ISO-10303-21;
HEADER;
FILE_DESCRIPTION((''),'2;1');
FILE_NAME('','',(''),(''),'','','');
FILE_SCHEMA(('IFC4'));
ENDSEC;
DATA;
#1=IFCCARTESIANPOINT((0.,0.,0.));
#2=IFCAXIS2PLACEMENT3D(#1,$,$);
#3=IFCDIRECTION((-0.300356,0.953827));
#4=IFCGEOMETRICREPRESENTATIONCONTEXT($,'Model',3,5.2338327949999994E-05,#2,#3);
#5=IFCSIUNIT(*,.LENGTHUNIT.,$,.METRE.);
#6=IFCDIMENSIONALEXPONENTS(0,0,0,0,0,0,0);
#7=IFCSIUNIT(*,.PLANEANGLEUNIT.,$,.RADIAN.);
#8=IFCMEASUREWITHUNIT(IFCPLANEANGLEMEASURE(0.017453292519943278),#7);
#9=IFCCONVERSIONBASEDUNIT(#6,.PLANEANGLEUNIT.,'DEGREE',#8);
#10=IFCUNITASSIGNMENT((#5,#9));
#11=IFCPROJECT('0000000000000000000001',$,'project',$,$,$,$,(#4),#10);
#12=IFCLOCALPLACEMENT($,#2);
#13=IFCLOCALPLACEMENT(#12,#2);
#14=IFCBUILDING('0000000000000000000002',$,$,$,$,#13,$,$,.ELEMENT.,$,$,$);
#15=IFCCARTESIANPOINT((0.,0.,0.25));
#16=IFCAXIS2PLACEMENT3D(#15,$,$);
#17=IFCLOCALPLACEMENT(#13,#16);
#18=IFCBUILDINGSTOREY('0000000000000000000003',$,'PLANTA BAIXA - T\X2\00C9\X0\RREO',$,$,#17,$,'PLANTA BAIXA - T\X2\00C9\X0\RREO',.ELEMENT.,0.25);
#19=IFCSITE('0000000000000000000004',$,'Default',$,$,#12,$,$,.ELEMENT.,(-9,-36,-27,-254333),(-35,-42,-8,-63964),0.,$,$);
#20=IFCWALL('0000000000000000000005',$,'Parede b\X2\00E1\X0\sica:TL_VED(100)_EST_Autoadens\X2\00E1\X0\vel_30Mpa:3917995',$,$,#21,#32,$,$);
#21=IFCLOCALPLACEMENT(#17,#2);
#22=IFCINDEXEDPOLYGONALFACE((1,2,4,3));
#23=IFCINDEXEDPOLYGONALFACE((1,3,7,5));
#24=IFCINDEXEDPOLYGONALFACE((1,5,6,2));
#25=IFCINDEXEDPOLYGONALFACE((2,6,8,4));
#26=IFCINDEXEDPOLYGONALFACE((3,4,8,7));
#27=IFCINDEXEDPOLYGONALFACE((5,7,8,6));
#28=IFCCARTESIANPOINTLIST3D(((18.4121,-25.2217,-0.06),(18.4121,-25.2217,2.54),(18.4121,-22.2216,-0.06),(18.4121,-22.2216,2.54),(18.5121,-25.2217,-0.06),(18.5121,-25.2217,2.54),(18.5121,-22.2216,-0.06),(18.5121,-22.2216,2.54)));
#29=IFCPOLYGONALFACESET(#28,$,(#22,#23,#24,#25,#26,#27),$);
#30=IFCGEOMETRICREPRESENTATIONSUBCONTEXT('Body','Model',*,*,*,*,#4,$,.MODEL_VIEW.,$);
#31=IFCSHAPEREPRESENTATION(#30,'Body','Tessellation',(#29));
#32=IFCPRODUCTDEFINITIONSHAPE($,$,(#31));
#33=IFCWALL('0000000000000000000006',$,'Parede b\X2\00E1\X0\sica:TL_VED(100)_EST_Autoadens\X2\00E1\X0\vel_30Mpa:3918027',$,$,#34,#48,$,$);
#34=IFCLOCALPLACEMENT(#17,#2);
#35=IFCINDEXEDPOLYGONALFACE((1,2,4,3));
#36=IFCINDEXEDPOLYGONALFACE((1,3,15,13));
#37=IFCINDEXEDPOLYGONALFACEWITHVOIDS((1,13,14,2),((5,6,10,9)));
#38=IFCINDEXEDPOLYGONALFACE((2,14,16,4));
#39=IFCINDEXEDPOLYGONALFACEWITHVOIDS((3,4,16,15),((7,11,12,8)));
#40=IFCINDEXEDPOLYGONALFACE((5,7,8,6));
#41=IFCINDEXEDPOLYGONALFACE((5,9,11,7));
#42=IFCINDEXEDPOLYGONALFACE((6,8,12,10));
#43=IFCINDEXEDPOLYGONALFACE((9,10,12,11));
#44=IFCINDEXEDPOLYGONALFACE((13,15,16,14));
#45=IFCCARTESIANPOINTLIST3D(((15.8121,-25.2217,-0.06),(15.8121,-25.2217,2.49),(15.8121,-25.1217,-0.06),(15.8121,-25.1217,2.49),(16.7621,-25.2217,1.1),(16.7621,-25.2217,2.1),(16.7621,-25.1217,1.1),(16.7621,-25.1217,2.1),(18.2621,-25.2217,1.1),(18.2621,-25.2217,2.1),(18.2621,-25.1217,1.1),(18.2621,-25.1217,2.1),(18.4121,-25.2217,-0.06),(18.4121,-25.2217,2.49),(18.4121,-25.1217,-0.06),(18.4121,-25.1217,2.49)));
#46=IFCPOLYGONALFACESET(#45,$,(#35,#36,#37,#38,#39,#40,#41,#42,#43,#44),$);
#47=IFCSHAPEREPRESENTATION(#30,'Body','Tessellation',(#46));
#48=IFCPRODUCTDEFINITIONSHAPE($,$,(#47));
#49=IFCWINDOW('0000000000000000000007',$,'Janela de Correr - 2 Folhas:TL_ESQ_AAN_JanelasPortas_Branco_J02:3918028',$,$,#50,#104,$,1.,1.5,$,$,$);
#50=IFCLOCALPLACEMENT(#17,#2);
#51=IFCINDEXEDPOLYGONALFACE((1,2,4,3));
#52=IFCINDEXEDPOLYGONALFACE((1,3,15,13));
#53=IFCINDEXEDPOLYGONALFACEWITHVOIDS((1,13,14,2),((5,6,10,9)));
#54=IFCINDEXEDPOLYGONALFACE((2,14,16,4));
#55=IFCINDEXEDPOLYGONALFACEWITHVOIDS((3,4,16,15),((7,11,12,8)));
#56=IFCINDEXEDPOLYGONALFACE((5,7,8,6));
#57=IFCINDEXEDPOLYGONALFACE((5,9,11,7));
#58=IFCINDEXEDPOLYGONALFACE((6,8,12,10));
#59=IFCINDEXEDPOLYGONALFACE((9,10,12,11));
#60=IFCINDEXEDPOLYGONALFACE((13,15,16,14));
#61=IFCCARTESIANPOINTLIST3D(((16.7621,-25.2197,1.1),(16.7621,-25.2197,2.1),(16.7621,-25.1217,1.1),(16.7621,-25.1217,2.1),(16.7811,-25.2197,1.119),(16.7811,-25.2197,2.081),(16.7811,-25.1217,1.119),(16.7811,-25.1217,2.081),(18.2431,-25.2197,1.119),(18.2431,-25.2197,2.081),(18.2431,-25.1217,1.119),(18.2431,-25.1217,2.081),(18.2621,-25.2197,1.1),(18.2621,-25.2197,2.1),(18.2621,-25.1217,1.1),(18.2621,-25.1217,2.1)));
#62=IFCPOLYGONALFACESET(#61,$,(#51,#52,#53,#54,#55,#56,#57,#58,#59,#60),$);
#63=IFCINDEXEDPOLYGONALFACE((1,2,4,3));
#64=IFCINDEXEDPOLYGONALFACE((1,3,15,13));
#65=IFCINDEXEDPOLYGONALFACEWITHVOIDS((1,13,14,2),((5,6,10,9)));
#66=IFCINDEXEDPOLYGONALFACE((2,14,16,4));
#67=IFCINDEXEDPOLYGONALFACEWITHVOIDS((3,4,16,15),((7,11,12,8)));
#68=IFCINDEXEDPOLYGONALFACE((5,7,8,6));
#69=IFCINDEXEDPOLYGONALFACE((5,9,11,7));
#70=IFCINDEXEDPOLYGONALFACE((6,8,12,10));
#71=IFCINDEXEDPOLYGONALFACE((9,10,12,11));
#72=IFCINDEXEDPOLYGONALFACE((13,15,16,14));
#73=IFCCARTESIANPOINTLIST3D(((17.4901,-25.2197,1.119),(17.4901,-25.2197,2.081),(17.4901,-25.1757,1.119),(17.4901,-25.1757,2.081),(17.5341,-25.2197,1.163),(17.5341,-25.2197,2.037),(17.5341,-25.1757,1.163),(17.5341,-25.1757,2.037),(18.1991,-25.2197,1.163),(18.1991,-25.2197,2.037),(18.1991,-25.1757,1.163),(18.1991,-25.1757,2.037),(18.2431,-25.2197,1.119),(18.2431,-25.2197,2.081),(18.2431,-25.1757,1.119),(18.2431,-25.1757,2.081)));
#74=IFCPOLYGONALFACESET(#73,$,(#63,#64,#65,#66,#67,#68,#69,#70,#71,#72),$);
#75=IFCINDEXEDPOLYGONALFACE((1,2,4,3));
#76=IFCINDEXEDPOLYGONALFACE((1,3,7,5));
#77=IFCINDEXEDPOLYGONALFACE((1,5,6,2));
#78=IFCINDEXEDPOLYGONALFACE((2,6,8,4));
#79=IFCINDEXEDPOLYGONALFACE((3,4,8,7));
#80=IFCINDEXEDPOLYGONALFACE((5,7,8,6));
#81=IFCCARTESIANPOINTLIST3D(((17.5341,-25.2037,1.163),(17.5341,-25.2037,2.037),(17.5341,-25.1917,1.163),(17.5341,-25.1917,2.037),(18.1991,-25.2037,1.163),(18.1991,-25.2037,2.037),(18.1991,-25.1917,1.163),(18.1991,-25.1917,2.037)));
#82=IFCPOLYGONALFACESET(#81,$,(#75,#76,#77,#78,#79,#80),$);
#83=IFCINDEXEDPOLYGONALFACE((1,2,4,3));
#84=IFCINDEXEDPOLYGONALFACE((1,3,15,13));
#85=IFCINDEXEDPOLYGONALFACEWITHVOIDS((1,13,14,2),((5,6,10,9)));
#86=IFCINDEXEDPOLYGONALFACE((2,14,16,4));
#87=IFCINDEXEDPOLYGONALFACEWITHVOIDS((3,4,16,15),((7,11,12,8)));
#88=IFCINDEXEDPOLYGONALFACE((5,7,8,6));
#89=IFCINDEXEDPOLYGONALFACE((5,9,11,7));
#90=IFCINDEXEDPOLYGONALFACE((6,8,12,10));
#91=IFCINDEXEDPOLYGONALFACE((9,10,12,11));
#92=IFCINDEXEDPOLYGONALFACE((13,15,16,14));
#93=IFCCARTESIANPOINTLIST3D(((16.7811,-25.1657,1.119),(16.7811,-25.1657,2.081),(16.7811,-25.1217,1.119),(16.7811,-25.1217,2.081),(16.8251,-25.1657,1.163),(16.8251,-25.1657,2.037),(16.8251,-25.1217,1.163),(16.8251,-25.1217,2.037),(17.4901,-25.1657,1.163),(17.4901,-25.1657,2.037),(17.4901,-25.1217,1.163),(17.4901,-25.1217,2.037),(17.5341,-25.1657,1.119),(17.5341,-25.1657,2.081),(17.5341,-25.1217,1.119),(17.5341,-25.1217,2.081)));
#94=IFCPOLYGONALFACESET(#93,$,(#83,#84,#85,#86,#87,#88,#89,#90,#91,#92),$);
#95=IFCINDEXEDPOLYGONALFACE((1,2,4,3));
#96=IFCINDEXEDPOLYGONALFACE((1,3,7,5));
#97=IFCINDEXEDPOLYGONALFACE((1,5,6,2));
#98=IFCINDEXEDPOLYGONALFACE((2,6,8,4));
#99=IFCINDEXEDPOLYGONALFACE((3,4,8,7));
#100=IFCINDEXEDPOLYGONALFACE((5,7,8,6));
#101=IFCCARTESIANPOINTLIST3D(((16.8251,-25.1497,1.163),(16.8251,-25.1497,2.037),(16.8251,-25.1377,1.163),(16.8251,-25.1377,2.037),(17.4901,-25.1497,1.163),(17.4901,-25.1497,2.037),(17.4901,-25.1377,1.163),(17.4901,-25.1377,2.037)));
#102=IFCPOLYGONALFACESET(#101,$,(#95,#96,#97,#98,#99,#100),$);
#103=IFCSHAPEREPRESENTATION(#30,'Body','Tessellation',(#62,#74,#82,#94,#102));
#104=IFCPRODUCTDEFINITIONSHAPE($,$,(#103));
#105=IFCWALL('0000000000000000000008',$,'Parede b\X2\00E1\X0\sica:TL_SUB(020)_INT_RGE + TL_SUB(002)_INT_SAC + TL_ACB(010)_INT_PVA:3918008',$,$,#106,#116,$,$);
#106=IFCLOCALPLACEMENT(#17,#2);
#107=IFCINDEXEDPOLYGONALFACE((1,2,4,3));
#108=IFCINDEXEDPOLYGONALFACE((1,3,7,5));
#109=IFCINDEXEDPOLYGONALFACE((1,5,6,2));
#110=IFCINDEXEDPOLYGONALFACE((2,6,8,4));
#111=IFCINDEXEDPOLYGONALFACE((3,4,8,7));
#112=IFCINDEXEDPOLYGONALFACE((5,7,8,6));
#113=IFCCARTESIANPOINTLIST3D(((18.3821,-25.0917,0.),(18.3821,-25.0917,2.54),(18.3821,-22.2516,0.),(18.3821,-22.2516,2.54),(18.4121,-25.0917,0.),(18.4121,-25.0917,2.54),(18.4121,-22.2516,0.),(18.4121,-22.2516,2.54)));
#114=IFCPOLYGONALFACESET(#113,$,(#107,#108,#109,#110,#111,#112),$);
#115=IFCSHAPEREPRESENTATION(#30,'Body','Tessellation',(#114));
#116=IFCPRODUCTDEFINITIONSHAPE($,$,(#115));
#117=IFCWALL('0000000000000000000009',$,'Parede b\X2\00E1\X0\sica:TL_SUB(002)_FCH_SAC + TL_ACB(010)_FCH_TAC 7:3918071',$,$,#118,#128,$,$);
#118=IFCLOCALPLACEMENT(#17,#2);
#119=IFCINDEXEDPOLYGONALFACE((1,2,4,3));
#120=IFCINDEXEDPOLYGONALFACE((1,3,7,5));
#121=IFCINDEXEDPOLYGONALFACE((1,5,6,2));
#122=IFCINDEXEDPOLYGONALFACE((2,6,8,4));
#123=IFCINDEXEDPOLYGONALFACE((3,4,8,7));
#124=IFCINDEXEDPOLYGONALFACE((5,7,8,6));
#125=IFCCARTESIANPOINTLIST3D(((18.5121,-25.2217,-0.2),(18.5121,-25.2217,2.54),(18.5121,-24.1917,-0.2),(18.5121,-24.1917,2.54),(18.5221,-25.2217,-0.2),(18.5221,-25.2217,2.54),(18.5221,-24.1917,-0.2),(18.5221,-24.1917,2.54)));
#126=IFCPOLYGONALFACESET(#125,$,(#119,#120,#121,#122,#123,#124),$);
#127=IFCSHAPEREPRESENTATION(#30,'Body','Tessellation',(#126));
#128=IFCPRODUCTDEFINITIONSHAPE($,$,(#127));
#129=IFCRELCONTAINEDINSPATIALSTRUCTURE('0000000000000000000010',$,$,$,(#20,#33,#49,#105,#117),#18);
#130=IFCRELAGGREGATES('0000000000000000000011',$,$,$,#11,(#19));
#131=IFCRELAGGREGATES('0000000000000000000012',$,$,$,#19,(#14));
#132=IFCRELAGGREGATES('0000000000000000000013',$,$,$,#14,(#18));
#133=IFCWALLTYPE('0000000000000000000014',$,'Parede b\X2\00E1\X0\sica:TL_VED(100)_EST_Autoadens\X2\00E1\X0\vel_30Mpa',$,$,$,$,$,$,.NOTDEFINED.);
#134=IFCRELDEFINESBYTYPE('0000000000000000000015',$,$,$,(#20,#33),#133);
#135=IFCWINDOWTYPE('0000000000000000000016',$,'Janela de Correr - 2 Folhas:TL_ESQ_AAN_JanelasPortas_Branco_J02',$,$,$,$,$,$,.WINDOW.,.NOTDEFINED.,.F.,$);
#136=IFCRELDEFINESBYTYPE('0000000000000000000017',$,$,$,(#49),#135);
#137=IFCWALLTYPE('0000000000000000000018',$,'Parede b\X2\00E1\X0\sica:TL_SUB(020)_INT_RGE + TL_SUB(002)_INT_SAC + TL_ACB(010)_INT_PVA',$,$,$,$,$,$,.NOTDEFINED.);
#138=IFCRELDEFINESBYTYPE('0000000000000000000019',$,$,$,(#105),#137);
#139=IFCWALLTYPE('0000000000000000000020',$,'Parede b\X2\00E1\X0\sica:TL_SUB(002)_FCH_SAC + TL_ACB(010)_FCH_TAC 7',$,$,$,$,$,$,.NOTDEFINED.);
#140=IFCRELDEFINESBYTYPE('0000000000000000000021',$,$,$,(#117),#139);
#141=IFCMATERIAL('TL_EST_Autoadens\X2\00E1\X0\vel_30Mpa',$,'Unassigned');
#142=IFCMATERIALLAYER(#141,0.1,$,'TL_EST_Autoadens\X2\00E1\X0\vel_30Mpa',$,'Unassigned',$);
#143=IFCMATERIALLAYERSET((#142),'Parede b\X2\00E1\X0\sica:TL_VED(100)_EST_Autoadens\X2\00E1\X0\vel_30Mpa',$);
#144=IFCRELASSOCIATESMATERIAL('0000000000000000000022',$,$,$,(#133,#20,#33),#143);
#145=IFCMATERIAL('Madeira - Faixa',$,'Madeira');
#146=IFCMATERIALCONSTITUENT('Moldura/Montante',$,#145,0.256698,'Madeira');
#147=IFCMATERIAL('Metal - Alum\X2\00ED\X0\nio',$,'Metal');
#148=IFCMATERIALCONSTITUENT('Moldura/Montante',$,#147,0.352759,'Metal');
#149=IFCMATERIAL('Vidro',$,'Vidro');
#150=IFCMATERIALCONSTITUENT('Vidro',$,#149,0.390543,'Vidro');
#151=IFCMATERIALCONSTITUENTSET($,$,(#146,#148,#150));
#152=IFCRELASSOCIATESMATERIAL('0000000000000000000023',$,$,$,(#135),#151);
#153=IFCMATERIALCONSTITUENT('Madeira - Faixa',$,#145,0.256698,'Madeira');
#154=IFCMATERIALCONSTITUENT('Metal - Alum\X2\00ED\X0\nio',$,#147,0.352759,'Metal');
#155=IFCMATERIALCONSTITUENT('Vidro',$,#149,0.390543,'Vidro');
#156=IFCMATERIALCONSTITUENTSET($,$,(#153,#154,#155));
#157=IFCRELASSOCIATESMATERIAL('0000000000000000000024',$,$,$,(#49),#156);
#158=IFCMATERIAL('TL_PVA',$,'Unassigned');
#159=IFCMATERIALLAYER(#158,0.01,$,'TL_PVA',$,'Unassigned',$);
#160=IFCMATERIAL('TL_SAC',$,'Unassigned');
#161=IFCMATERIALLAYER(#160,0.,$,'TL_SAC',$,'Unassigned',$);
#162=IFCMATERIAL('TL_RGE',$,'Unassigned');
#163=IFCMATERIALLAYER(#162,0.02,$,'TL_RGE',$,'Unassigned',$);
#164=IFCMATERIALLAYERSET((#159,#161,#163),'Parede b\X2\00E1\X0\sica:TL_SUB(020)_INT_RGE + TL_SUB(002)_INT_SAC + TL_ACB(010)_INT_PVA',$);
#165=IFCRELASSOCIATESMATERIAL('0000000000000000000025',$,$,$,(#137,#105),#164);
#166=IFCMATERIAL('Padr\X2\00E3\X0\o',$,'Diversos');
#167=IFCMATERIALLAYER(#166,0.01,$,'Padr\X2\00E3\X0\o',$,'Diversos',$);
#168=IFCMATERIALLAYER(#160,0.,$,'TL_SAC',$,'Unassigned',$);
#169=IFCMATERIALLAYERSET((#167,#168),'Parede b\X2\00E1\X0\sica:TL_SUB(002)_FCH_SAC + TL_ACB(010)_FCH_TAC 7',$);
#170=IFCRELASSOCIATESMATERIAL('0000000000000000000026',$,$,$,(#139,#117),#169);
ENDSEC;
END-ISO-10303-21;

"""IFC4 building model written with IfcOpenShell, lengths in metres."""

from ifc_helpers import new_model, entity, si_unit, converted_unit, direction, frame, frame_2d, origin, origin_2d_with_axis, place, context, subcontext, project, spatial, polyline, rectangle, outline, extrude, source, transform, mapped, material, layer, layer_set, layer_usage, constituent, constituent_set, type_object, type_shapes, element, fill, save


model = new_model("IFC4")

# Units and contexts
model_context = context("Model", 3, precision=5.2338327949999994e-05, world=origin(), true_north=direction((-0.300356, 0.953827)))
body_context = subcontext(model_context, "Body", "Model", "MODEL_VIEW")
ifc_project = project(units=[si_unit("LENGTHUNIT", "METRE"), converted_unit("PLANEANGLEUNIT", "DEGREE", entity("IfcPlaneAngleMeasure", 0.017453292519943278), si_unit("PLANEANGLEUNIT", "RADIAN"), dimensions=[0, 0, 0, 0, 0, 0, 0])], contexts=[model_context])

# Site, building, storey
site_placement = place(None, origin())
site = spatial("IfcSite", under=ifc_project, at=site_placement, Name="Default", CompositionType="ELEMENT", RefLatitude=(-9, -36, -27, -254333), RefLongitude=(-35, -42, -8, -63964), RefElevation=0.0)
building_placement = place(site_placement, origin())
building = spatial("IfcBuilding", under=site, at=building_placement, CompositionType="ELEMENT")
storey_placement = place(building_placement, frame((0.0, 0.0, 0.25)))
storey = spatial("IfcBuildingStorey", under=building, at=storey_placement, Name="PLANTA BAIXA - TÉRREO", LongName="PLANTA BAIXA - TÉRREO", CompositionType="ELEMENT", Elevation=0.25)

# Wall
ifc_material_1 = material(Name="TL_EST_Autoadensável_30Mpa", Category="Unassigned")
ifc_layer_1 = layer(ifc_material_1, 0.1, Name="TL_EST_Autoadensável_30Mpa", Category="Unassigned")
ifc_layer_set_1 = layer_set([ifc_layer_1], Name="Parede básica:TL_VED(100)_EST_Autoadensável_30Mpa")
ifc_layer_usage_1 = layer_usage(ifc_layer_set_1, "AXIS2", "NEGATIVE", 0.05)
wall_type_1 = type_object("IfcWallType", Name="Parede básica:TL_VED(100)_EST_Autoadensável_30Mpa", PredefinedType="NOTDEFINED", material=ifc_layer_set_1)
wall_1_placement = place(storey_placement, frame((18.4621, -25.2217, -0.06), z_axis=(0.0, 0.0, 1.0), x_axis=(0.0, 1.0, 0.0)))
element("IfcWall", 1, at=wall_1_placement, inside=storey, type_object=wall_type_1, material=ifc_layer_usage_1, Name="Parede básica:TL_VED(100)_EST_Autoadensável_30Mpa:3917995", context=body_context, shape_type="SweptSolid", body=[
    extrude(rectangle(XDim=3.0001, YDim=0.1, at=frame_2d((1.5001, 0.0), x_axis=(-1.0, 0.0))), origin(), (0.0, 0.0, 1.0), 2.6),
])

# Wall, opening, window
ifc_layer_usage_2 = layer_usage(ifc_layer_set_1, "AXIS2", "NEGATIVE", 0.05)
wall_2_placement = place(storey_placement, frame((18.4121, -25.1717, -0.06), z_axis=(0.0, 0.0, 1.0), x_axis=(-1.0, 0.0, 0.0)))
wall_2 = element("IfcWall", 2, at=wall_2_placement, inside=storey, type_object=wall_type_1, material=ifc_layer_usage_2, Name="Parede básica:TL_VED(100)_EST_Autoadensável_30Mpa:3918027", context=body_context, shape_type="SweptSolid", body=[
    extrude(rectangle(XDim=2.6, YDim=0.1, at=frame_2d((1.3, 0.0), x_axis=(-1.0, 0.0))), origin(), (0.0, 0.0, 1.0), 2.55),
])
opening_placement = place(wall_2_placement, frame((0.15, -0.05, 1.16)))
opening = element("IfcOpeningElement", 3, at=opening_placement, cuts=wall_2, PredefinedType="OPENING", context=body_context, shape_type="SweptSolid", body=[
    extrude(rectangle(XDim=1.0, YDim=1.5, at=frame_2d((0.5, 0.75), x_axis=(-1.0, 0.0))), frame((0.0, 0.0, 0.0), z_axis=(0.0, 1.0, 0.0), x_axis=(0.0, 0.0, 1.0)), (0.0, 0.0, 1.0), 0.1),
])
ifc_material_2 = material(Name="Madeira - Faixa", Category="Madeira")
ifc_constituent_1 = constituent(ifc_material_2, Name="Madeira - Faixa", Category="Madeira", fraction=0.256698)
ifc_material_3 = material(Name="Metal - Alumínio", Category="Metal")
ifc_constituent_2 = constituent(ifc_material_3, Name="Metal - Alumínio", Category="Metal", fraction=0.352759)
ifc_material_4 = material(Name="Vidro", Category="Vidro")
ifc_constituent_3 = constituent(ifc_material_4, Name="Vidro", Category="Vidro", fraction=0.390543)
ifc_constituent_set_1 = constituent_set(constituents=[ifc_constituent_1, ifc_constituent_2, ifc_constituent_3])
ifc_constituent_4 = constituent(ifc_material_2, Name="Moldura/Montante", Category="Madeira", fraction=0.256698)
ifc_constituent_5 = constituent(ifc_material_3, Name="Moldura/Montante", Category="Metal", fraction=0.352759)
ifc_constituent_6 = constituent(ifc_material_4, Name="Vidro", Category="Vidro", fraction=0.390543)
ifc_constituent_set_2 = constituent_set(constituents=[ifc_constituent_4, ifc_constituent_5, ifc_constituent_6])
window_type = type_object("IfcWindowType", Name="Janela de Correr - 2 Folhas:TL_ESQ_AAN_JanelasPortas_Branco_J02", ParameterTakesPrecedence=False, PartitioningType="NOTDEFINED", PredefinedType="WINDOW", material=ifc_constituent_set_2)
shared_shape_1 = source(origin(), body_context, "Body", "SweptSolid", [
    extrude(outline(polyline([(-0.75, -0.5), (0.75, -0.5), (0.75, 0.5), (-0.75, 0.5), (-0.75, -0.5)]), holes=[polyline([(-0.731, -0.481), (-0.731, 0.481), (0.731, 0.481), (0.731, -0.481), (-0.731, -0.481)])]), frame((0.75, 0.124, 0.5), z_axis=(0.0, -1.0, 0.0), x_axis=(-1.0, 0.0, 0.0)), (0.0, 0.0, 1.0), 0.098),
    extrude(outline(polyline([(-0.3765, -0.481), (0.3765, -0.481), (0.3765, 0.481), (-0.3765, 0.481), (-0.3765, -0.481)]), holes=[polyline([(-0.3325, -0.437), (-0.3325, 0.437), (0.3325, 0.437), (0.3325, -0.437), (-0.3325, -0.437)])]), frame((0.3955, 0.124, 0.5), z_axis=(0.0, -1.0, 0.0), x_axis=(-1.0, 0.0, 0.0)), (0.0, 0.0, 1.0), 0.044),
    extrude(rectangle(XDim=0.665, YDim=0.012, at=origin_2d_with_axis()), frame((0.3955, 0.102, 0.063), z_axis=(0.0, 0.0, 1.0), x_axis=(-1.0, 0.0, 0.0)), (0.0, 0.0, 1.0), 0.874),
    extrude(outline(polyline([(-0.481, -0.3765), (0.481, -0.3765), (0.481, 0.3765), (-0.481, 0.3765), (-0.481, -0.3765)]), holes=[polyline([(-0.437, -0.3325), (-0.437, 0.3325), (0.437, 0.3325), (0.437, -0.3325), (-0.437, -0.3325)])]), frame((1.1045, 0.07, 0.5), z_axis=(0.0, -1.0, 0.0), x_axis=(0.0, 0.0, -1.0)), (0.0, 0.0, 1.0), 0.044),
    extrude(rectangle(XDim=0.665, YDim=0.012, at=origin_2d_with_axis()), frame((1.1045, 0.048, 0.063), z_axis=(0.0, 0.0, 1.0), x_axis=(-1.0, 0.0, 0.0)), (0.0, 0.0, 1.0), 0.874),
])
type_shapes(window_type, [shared_shape_1])
window_placement = place(opening_placement, frame((0.0, -0.026, 0.0)))
window = element("IfcWindow", 4, at=window_placement, inside=storey, type_object=window_type, material=ifc_constituent_set_1, Name="Janela de Correr - 2 Folhas:TL_ESQ_AAN_JanelasPortas_Branco_J02:3918028", OverallHeight=1.0, OverallWidth=1.5, context=body_context, shape_type="MappedRepresentation", body=[
    mapped(shared_shape_1, transform((0.0, 0.0, 0.0), scale=1.0)),
])
fill(opening, window)

# Walls
ifc_material_5 = material(Name="TL_PVA", Category="Unassigned")
ifc_layer_2 = layer(ifc_material_5, 0.01, Name="TL_PVA", Category="Unassigned")
ifc_material_6 = material(Name="TL_SAC", Category="Unassigned")
ifc_layer_3 = layer(ifc_material_6, 0.0, Name="TL_SAC", Category="Unassigned")
ifc_material_7 = material(Name="TL_RGE", Category="Unassigned")
ifc_layer_4 = layer(ifc_material_7, 0.02, Name="TL_RGE", Category="Unassigned")
ifc_layer_set_2 = layer_set([ifc_layer_2, ifc_layer_3, ifc_layer_4], Name="Parede básica:TL_SUB(020)_INT_RGE + TL_SUB(002)_INT_SAC + TL_ACB(010)_INT_PVA")
ifc_layer_usage_3 = layer_usage(ifc_layer_set_2, "AXIS2", "NEGATIVE", 0.015)
wall_type_2 = type_object("IfcWallType", Name="Parede básica:TL_SUB(020)_INT_RGE + TL_SUB(002)_INT_SAC + TL_ACB(010)_INT_PVA", PredefinedType="NOTDEFINED", material=ifc_layer_set_2)
wall_3_placement = place(storey_placement, frame((18.3971, -25.0917, 0.0), z_axis=(0.0, 0.0, 1.0), x_axis=(0.0, 1.0, 0.0)))
element("IfcWall", 5, at=wall_3_placement, inside=storey, type_object=wall_type_2, material=ifc_layer_usage_3, Name="Parede básica:TL_SUB(020)_INT_RGE + TL_SUB(002)_INT_SAC + TL_ACB(010)_INT_PVA:3918008", context=body_context, shape_type="SweptSolid", body=[
    extrude(rectangle(XDim=2.8401, YDim=0.03, at=frame_2d((1.4201, 0.0), x_axis=(-1.0, 0.0))), origin(), (0.0, 0.0, 1.0), 2.54),
])
ifc_material_8 = material(Name="Padrão", Category="Diversos")
ifc_layer_5 = layer(ifc_material_8, 0.01, Name="Padrão", Category="Diversos")
ifc_layer_6 = layer(ifc_material_6, 0.0, Name="TL_SAC", Category="Unassigned")
ifc_layer_set_3 = layer_set([ifc_layer_5, ifc_layer_6], Name="Parede básica:TL_SUB(002)_FCH_SAC + TL_ACB(010)_FCH_TAC 7")
ifc_layer_usage_4 = layer_usage(ifc_layer_set_3, "AXIS2", "NEGATIVE", 0.005)
wall_type_3 = type_object("IfcWallType", Name="Parede básica:TL_SUB(002)_FCH_SAC + TL_ACB(010)_FCH_TAC 7", PredefinedType="NOTDEFINED", material=ifc_layer_set_3)
wall_4_placement = place(storey_placement, frame((18.5171, -25.2217, -0.2), z_axis=(0.0, 0.0, 1.0), x_axis=(0.0, 1.0, 0.0)))
element("IfcWall", 6, at=wall_4_placement, inside=storey, type_object=wall_type_3, material=ifc_layer_usage_4, Name="Parede básica:TL_SUB(002)_FCH_SAC + TL_ACB(010)_FCH_TAC 7:3918071", context=body_context, shape_type="SweptSolid", body=[
    extrude(rectangle(XDim=1.03, YDim=0.01, at=frame_2d((0.515, 0.0), x_axis=(-1.0, 0.0))), origin(), (0.0, 0.0, 1.0), 2.74),
])

save(model, "model.ifc")
